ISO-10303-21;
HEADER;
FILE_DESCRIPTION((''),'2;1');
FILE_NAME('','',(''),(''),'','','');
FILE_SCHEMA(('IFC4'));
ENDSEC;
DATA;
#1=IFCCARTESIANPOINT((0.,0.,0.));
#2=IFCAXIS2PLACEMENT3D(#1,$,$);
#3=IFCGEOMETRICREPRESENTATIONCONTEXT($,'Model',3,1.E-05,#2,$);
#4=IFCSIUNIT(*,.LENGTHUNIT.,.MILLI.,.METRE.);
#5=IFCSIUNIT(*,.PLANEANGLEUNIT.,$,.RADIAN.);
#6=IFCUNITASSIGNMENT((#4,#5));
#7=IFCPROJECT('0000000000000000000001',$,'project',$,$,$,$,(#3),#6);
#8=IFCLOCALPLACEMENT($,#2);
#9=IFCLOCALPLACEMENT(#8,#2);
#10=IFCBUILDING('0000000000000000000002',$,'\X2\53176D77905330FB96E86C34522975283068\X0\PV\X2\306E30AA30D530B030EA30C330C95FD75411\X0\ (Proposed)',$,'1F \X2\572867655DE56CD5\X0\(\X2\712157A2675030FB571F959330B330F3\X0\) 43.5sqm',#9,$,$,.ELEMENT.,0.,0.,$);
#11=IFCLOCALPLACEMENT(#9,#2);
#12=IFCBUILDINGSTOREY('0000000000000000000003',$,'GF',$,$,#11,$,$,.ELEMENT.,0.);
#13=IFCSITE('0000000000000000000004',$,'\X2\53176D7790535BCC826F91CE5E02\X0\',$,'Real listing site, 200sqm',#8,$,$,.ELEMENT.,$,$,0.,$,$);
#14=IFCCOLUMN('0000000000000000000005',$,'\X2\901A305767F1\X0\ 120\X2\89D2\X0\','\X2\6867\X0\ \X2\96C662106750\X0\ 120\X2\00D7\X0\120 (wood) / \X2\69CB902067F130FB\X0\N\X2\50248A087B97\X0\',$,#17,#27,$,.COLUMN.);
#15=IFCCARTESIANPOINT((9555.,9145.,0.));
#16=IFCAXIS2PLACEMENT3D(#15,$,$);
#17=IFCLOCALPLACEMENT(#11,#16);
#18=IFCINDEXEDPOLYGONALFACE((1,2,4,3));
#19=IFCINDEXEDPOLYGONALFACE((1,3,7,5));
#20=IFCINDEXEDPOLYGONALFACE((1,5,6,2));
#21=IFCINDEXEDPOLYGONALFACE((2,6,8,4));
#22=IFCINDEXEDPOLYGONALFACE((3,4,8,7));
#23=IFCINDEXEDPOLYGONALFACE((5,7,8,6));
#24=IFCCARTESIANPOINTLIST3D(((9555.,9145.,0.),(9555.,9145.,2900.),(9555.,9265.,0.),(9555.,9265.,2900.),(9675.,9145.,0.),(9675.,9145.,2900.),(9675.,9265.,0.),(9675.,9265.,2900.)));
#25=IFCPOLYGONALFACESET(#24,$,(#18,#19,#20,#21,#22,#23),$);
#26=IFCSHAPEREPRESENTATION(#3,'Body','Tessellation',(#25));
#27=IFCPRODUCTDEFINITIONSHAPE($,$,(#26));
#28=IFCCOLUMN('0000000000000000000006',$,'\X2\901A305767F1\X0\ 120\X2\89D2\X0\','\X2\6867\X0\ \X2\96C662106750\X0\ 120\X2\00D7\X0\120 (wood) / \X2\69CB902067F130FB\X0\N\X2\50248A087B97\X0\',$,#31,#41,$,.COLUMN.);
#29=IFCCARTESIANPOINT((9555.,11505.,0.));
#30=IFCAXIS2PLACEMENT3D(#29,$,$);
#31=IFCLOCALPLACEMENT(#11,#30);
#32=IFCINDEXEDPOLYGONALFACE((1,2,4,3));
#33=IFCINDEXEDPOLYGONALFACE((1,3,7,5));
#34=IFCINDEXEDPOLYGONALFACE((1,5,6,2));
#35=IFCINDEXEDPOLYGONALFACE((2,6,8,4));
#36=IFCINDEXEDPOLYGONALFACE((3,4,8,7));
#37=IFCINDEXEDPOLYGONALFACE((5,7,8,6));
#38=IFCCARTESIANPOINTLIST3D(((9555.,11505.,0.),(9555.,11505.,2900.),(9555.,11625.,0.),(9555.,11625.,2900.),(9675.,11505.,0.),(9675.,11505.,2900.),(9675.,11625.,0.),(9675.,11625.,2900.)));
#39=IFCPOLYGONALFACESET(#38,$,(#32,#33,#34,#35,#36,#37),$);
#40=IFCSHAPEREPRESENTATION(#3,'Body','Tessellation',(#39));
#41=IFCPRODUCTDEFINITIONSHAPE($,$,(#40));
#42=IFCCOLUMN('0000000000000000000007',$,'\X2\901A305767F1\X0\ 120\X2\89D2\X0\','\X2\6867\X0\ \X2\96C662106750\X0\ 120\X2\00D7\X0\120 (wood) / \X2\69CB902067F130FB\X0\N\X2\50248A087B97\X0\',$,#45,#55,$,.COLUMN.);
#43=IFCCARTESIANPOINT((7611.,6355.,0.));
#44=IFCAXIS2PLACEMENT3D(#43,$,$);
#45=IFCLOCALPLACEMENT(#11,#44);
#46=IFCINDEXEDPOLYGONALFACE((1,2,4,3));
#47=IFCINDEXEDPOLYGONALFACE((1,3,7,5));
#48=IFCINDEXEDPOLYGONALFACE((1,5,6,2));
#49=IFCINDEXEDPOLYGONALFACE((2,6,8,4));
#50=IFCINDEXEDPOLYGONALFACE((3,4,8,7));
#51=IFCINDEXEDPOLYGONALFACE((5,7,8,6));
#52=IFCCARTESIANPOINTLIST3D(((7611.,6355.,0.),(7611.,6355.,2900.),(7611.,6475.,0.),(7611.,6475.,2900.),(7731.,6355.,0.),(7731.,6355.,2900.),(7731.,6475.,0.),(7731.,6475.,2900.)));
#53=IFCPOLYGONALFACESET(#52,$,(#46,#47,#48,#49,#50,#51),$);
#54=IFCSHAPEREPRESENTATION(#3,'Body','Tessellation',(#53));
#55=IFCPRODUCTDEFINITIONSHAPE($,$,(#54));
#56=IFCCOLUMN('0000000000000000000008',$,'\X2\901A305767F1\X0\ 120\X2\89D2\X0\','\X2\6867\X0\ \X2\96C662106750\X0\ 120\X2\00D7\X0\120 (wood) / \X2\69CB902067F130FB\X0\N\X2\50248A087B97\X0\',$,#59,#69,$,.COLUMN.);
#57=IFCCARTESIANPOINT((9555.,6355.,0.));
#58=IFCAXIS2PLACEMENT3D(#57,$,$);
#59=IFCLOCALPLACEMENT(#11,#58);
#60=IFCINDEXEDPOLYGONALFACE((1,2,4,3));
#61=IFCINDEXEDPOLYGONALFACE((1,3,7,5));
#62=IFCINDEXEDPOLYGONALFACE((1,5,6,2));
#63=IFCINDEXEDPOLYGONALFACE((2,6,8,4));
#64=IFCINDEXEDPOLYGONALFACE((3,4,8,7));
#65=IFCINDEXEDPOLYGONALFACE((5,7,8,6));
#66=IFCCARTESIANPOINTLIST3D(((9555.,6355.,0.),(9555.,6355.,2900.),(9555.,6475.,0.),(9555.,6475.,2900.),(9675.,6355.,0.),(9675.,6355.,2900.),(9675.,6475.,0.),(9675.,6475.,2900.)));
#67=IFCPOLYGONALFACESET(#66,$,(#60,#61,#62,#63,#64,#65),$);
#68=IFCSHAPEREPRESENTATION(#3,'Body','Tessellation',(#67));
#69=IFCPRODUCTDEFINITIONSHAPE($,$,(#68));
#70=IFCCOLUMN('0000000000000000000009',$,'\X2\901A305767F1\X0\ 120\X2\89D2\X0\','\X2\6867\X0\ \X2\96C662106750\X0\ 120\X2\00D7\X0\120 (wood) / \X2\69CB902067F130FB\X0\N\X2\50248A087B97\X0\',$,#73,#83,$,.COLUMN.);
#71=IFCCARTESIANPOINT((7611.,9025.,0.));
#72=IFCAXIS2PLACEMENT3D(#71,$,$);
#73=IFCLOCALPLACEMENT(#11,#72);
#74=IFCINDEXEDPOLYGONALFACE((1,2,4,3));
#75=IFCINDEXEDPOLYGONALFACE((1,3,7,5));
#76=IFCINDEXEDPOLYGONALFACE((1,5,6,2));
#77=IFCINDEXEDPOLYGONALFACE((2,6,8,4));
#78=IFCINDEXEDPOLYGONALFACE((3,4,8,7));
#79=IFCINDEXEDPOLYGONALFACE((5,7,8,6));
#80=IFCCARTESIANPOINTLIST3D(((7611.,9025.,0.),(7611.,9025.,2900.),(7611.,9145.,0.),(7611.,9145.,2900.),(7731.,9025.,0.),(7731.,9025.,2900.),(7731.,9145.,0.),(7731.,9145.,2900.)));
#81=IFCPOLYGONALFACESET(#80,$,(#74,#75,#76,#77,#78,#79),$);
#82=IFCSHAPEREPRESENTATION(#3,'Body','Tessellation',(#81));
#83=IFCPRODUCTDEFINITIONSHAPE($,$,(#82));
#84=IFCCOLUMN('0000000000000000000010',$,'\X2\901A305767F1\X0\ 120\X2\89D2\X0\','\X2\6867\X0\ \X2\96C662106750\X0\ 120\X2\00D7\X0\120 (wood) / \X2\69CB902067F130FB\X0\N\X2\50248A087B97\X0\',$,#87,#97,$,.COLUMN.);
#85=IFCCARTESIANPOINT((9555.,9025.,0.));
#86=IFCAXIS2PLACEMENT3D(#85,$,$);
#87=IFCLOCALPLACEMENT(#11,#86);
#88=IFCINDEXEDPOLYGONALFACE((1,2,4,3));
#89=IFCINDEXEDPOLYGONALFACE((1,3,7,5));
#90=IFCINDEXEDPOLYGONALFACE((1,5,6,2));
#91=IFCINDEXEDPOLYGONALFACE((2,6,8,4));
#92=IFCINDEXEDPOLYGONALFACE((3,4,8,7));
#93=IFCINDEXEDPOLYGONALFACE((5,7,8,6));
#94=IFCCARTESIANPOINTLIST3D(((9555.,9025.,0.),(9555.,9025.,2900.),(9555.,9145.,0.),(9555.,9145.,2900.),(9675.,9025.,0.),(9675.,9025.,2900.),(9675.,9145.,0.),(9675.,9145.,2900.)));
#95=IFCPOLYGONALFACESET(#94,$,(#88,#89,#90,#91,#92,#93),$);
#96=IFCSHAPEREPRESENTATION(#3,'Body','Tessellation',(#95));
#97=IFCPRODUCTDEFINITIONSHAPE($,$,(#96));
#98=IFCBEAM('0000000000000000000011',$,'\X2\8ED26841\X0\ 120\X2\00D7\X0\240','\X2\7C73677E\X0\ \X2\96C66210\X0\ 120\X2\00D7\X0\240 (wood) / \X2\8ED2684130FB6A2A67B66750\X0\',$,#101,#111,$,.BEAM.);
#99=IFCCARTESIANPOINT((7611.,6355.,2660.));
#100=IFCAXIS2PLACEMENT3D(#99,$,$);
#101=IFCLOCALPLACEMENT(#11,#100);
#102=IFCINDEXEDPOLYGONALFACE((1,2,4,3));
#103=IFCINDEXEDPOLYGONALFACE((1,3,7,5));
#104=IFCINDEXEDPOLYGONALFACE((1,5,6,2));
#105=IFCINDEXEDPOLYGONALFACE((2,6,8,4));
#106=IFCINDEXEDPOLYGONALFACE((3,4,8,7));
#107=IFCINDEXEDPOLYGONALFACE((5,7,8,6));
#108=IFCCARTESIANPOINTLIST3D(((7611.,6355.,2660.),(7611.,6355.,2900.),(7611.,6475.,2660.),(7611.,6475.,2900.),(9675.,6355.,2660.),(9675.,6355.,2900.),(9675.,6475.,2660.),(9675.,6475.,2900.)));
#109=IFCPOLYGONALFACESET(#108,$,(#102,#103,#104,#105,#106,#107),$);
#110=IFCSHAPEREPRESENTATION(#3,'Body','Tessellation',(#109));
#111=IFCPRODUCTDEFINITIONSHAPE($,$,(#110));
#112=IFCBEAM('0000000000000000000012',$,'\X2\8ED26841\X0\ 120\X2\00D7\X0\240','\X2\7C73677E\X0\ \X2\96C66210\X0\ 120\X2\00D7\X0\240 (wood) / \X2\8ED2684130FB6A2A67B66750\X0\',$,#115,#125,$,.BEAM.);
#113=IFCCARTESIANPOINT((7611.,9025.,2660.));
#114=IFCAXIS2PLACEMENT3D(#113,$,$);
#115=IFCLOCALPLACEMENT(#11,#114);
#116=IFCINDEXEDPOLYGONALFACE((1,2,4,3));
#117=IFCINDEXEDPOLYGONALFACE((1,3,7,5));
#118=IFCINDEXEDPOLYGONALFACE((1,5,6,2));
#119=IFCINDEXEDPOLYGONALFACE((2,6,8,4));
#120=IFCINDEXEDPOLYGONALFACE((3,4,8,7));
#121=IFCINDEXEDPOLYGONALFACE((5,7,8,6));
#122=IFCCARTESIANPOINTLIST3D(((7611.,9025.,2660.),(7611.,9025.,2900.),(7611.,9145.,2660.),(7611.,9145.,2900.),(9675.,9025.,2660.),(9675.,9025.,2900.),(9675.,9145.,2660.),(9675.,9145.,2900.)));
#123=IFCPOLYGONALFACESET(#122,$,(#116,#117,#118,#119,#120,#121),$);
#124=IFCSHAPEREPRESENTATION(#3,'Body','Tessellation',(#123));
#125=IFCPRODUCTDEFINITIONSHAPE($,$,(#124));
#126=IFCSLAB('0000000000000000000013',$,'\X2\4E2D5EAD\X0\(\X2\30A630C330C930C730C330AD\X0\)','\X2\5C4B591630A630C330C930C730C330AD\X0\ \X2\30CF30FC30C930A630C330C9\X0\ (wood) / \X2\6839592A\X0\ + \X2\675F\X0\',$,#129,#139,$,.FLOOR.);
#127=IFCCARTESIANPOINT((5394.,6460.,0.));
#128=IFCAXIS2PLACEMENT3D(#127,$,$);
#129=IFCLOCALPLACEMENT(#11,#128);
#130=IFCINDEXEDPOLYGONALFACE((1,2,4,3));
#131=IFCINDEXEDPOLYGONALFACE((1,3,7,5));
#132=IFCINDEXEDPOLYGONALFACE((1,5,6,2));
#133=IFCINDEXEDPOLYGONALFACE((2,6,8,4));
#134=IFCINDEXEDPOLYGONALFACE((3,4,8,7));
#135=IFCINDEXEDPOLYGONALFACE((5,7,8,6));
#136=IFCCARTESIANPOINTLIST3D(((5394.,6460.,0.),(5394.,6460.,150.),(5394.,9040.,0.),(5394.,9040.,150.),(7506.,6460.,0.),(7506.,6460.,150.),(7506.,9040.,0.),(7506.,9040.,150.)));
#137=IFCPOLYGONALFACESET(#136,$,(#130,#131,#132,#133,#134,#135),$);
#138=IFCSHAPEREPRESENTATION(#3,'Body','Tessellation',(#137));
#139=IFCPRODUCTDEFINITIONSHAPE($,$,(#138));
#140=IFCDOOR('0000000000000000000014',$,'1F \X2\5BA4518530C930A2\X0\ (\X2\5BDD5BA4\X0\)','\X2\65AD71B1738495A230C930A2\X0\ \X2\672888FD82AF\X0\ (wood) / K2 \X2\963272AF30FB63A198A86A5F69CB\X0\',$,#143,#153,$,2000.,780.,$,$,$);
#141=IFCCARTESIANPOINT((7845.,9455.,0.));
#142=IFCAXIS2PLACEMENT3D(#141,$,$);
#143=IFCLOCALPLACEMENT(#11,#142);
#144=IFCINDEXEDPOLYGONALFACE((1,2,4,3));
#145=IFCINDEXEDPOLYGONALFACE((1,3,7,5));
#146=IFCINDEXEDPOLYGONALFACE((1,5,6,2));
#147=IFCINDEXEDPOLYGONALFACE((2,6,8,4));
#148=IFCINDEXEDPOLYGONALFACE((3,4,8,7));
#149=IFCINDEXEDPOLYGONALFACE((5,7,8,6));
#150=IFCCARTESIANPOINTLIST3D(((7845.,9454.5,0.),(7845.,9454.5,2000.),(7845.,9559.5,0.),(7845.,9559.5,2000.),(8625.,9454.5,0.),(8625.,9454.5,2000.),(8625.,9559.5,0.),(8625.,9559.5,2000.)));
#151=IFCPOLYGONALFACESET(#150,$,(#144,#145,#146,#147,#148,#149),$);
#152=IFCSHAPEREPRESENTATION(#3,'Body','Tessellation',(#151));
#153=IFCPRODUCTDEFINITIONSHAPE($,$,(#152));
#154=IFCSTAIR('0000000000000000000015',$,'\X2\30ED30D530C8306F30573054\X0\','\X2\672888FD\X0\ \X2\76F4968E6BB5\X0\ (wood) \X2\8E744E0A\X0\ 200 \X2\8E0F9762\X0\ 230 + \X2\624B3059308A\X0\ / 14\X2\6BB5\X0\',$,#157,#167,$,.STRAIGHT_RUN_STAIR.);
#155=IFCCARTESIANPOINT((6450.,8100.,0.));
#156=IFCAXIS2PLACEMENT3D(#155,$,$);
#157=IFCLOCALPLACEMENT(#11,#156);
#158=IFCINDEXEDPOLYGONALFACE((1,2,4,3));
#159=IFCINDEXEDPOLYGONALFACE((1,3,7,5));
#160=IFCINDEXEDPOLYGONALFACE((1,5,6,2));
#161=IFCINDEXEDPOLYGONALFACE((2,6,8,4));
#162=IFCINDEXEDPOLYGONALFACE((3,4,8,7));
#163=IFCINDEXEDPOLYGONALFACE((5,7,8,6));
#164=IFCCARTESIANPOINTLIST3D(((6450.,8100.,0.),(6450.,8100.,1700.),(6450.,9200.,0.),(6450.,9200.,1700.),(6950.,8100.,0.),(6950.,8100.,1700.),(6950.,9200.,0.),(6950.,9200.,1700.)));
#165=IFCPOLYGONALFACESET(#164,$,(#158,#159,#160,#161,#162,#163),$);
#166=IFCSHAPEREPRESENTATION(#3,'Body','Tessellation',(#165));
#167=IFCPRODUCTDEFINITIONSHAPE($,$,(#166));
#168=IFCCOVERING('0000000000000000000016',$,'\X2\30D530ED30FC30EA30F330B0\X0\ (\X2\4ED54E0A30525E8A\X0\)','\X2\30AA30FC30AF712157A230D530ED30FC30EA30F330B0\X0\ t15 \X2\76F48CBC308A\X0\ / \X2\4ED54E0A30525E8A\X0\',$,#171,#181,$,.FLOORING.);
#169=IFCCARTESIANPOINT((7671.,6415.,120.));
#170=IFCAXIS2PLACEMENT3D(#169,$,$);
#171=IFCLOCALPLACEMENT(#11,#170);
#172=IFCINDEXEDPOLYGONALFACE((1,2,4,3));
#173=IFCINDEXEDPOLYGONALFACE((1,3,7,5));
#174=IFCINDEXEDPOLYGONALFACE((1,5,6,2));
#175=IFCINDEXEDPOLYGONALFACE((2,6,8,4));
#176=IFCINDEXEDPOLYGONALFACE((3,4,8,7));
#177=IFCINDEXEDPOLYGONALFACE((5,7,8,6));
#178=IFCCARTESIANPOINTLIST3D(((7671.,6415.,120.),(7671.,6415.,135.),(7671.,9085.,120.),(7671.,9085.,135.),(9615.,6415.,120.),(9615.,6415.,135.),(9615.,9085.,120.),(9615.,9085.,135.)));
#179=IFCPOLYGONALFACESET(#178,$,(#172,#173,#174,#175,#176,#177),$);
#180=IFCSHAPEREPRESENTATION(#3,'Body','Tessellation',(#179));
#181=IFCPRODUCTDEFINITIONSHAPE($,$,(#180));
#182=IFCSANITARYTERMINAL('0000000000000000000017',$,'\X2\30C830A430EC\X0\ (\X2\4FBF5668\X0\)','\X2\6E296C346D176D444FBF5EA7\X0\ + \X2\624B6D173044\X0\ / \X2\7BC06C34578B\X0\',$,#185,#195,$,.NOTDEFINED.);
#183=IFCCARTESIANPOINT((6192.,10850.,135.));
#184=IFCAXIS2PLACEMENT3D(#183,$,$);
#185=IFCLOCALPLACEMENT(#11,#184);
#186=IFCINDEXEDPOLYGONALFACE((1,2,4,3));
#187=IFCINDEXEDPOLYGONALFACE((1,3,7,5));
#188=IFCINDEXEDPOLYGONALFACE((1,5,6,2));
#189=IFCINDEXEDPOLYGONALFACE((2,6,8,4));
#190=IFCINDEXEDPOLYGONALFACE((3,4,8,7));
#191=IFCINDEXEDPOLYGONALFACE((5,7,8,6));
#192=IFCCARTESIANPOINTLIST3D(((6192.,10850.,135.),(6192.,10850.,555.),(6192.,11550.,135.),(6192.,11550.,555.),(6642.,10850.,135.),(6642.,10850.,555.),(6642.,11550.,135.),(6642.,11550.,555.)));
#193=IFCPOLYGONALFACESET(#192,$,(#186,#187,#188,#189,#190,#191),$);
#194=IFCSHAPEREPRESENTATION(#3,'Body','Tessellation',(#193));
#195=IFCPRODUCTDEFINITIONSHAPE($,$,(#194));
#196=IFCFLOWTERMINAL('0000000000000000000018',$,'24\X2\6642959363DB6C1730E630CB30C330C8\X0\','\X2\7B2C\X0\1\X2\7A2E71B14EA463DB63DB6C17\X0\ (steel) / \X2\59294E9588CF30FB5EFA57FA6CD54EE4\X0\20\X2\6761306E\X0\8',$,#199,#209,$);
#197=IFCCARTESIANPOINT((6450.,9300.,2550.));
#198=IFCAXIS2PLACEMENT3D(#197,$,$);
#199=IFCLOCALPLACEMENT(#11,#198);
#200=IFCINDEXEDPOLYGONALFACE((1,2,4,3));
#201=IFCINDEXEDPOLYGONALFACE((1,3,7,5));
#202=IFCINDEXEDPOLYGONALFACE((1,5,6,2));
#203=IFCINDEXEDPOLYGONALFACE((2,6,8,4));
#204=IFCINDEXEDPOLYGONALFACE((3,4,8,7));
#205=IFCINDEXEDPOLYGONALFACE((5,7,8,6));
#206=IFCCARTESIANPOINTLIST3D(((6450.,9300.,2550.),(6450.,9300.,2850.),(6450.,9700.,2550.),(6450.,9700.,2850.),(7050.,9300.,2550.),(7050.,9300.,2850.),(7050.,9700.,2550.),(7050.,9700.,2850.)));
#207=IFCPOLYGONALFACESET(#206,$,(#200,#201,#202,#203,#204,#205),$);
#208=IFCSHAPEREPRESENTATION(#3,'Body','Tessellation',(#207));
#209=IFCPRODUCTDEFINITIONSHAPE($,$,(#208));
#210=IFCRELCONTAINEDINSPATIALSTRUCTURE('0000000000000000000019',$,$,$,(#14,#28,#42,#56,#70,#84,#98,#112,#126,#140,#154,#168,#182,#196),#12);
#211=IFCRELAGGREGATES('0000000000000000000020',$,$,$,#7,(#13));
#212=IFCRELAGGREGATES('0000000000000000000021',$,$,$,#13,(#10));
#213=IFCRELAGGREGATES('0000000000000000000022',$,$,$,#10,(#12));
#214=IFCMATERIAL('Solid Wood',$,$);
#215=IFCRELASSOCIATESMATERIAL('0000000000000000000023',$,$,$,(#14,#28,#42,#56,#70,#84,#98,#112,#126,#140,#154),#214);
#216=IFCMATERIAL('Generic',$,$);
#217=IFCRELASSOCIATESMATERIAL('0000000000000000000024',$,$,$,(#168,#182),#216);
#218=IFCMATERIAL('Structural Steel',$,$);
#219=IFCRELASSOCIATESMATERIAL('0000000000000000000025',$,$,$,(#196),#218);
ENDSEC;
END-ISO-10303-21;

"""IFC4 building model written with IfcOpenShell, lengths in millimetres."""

from ifc_helpers import new_model, si_unit, frame, frame_2d, origin, place, context, project, spatial, rectangle, extrude, material, element, save


model = new_model("IFC4")

# Units and contexts
model_context = context("Model", 3, precision=1e-05, world=origin())
ifc_project = project(units=[si_unit("LENGTHUNIT", "METRE", prefix="MILLI"), si_unit("PLANEANGLEUNIT", "RADIAN")], contexts=[model_context])

# Site, building, storey
site_placement = place(None, origin())
site = spatial("IfcSite", under=ifc_project, at=site_placement, Name="北海道富良野市", ObjectType="Real listing site, 200sqm", CompositionType="ELEMENT", RefElevation=0.0)
building_placement = place(site_placement, origin())
building = spatial("IfcBuilding", under=site, at=building_placement, Name="北海道・雨水利用とPVのオフグリッド志向 (Proposed)", ObjectType="1F 在来工法(無垢材・土間コン) 43.5sqm", CompositionType="ELEMENT", ElevationOfRefHeight=0.0, ElevationOfTerrain=0.0)
storey_placement = place(building_placement, origin())
storey = spatial("IfcBuildingStorey", under=building, at=storey_placement, Name="GF", CompositionType="ELEMENT", Elevation=0.0)

# Columns
ifc_material_1 = material(Name="Solid Wood")
column_1_placement = place(storey_placement, frame((9555.0, 9145.0, 0.0)))
element("IfcColumn", 1, at=column_1_placement, inside=storey, material=ifc_material_1, Name="通し柱 120角", Description="桧 集成材 120×120 (wood) / 構造柱・N値計算", PredefinedType="COLUMN", context=model_context, shape_type="SweptSolid", body=[
    extrude(rectangle(XDim=120.0, YDim=120.0, at=frame_2d((60.0, 60.0))), frame((9555.0, 9145.0, 0.0)), (0.0, 0.0, 1.0), 2900.0),
])
column_2_placement = place(storey_placement, frame((9555.0, 11505.0, 0.0)))
element("IfcColumn", 2, at=column_2_placement, inside=storey, material=ifc_material_1, Name="通し柱 120角", Description="桧 集成材 120×120 (wood) / 構造柱・N値計算", PredefinedType="COLUMN", context=model_context, shape_type="SweptSolid", body=[
    extrude(rectangle(XDim=120.0, YDim=120.0, at=frame_2d((60.0, 60.0))), frame((9555.0, 11505.0, 0.0)), (0.0, 0.0, 1.0), 2900.0),
])
column_3_placement = place(storey_placement, frame((7611.0, 6355.0, 0.0)))
element("IfcColumn", 3, at=column_3_placement, inside=storey, material=ifc_material_1, Name="通し柱 120角", Description="桧 集成材 120×120 (wood) / 構造柱・N値計算", PredefinedType="COLUMN", context=model_context, shape_type="SweptSolid", body=[
    extrude(rectangle(XDim=120.0, YDim=120.0, at=frame_2d((60.0, 60.0))), frame((7611.0, 6355.0, 0.0)), (0.0, 0.0, 1.0), 2900.0),
])
column_4_placement = place(storey_placement, frame((9555.0, 6355.0, 0.0)))
element("IfcColumn", 4, at=column_4_placement, inside=storey, material=ifc_material_1, Name="通し柱 120角", Description="桧 集成材 120×120 (wood) / 構造柱・N値計算", PredefinedType="COLUMN", context=model_context, shape_type="SweptSolid", body=[
    extrude(rectangle(XDim=120.0, YDim=120.0, at=frame_2d((60.0, 60.0))), frame((9555.0, 6355.0, 0.0)), (0.0, 0.0, 1.0), 2900.0),
])
column_5_placement = place(storey_placement, frame((7611.0, 9025.0, 0.0)))
element("IfcColumn", 5, at=column_5_placement, inside=storey, material=ifc_material_1, Name="通し柱 120角", Description="桧 集成材 120×120 (wood) / 構造柱・N値計算", PredefinedType="COLUMN", context=model_context, shape_type="SweptSolid", body=[
    extrude(rectangle(XDim=120.0, YDim=120.0, at=frame_2d((60.0, 60.0))), frame((7611.0, 9025.0, 0.0)), (0.0, 0.0, 1.0), 2900.0),
])
column_6_placement = place(storey_placement, frame((9555.0, 9025.0, 0.0)))
element("IfcColumn", 6, at=column_6_placement, inside=storey, material=ifc_material_1, Name="通し柱 120角", Description="桧 集成材 120×120 (wood) / 構造柱・N値計算", PredefinedType="COLUMN", context=model_context, shape_type="SweptSolid", body=[
    extrude(rectangle(XDim=120.0, YDim=120.0, at=frame_2d((60.0, 60.0))), frame((9555.0, 9025.0, 0.0)), (0.0, 0.0, 1.0), 2900.0),
])

# Beams
beam_1_placement = place(storey_placement, frame((7611.0, 6355.0, 2660.0)))
element("IfcBeam", 7, at=beam_1_placement, inside=storey, material=ifc_material_1, Name="軒桁 120×240", Description="米松 集成 120×240 (wood) / 軒桁・横架材", PredefinedType="BEAM", context=model_context, shape_type="SweptSolid", body=[
    extrude(rectangle(XDim=2064.0, YDim=120.0, at=frame_2d((1032.0, 60.0))), frame((7611.0, 6355.0, 2660.0)), (0.0, 0.0, 1.0), 240.0),
])
beam_2_placement = place(storey_placement, frame((7611.0, 9025.0, 2660.0)))
element("IfcBeam", 8, at=beam_2_placement, inside=storey, material=ifc_material_1, Name="軒桁 120×240", Description="米松 集成 120×240 (wood) / 軒桁・横架材", PredefinedType="BEAM", context=model_context, shape_type="SweptSolid", body=[
    extrude(rectangle(XDim=2064.0, YDim=120.0, at=frame_2d((1032.0, 60.0))), frame((7611.0, 9025.0, 2660.0)), (0.0, 0.0, 1.0), 240.0),
])

# Slab
slab_placement = place(storey_placement, frame((5394.0, 6460.0, 0.0)))
element("IfcSlab", 9, at=slab_placement, inside=storey, material=ifc_material_1, Name="中庭(ウッドデッキ)", Description="屋外ウッドデッキ ハードウッド (wood) / 根太 + 束", PredefinedType="FLOOR", context=model_context, shape_type="SweptSolid", body=[
    extrude(rectangle(XDim=2112.0, YDim=2580.0, at=frame_2d((1056.0, 1290.0))), frame((5394.0, 6460.0, 0.0)), (0.0, 0.0, 1.0), 150.0),
])

# Door
door_placement = place(storey_placement, frame((7845.0, 9455.0, 0.0)))
element("IfcDoor", 10, at=door_placement, inside=storey, material=ifc_material_1, Name="1F 室内ドア (寝室)", Description="断熱玄関ドア 木製芯 (wood) / K2 防犯・採風機構", OverallHeight=2000.0, OverallWidth=780.0, context=model_context, shape_type="SweptSolid", body=[
    extrude(rectangle(XDim=780.0, YDim=105.0, at=frame_2d((390.0, 52.0))), frame((7845.0, 9455.0, 0.0)), (0.0, 0.0, 1.0), 2000.0),
])

# Stair
stair_placement = place(storey_placement, frame((6450.0, 8100.0, 0.0)))
element("IfcStair", 11, at=stair_placement, inside=storey, material=ifc_material_1, Name="ロフトはしご", Description="木製 直階段 (wood) 蹴上 200 踏面 230 + 手すり / 14段", PredefinedType="STRAIGHT_RUN_STAIR", context=model_context, shape_type="SweptSolid", body=[
    extrude(rectangle(XDim=500.0, YDim=1100.0, at=frame_2d((250.0, 550.0))), frame((6450.0, 8100.0, 0.0)), (0.0, 0.0, 1.0), 1700.0),
])

# Covering
ifc_material_2 = material(Name="Generic")
covering_placement = place(storey_placement, frame((7671.0, 6415.0, 120.0)))
element("IfcCovering", 12, at=covering_placement, inside=storey, material=ifc_material_2, Name="フローリング (仕上げ床)", Description="オーク無垢フローリング t15 直貼り / 仕上げ床", PredefinedType="FLOORING", context=model_context, shape_type="SweptSolid", body=[
    extrude(rectangle(XDim=1944.0, YDim=2670.0, at=frame_2d((972.0, 1335.0))), frame((7671.0, 6415.0, 120.0)), (0.0, 0.0, 1.0), 15.0),
])

# Sanitary terminal
sanitary_terminal_placement = place(storey_placement, frame((6192.0, 10850.0, 135.0)))
element("IfcSanitaryTerminal", 13, at=sanitary_terminal_placement, inside=storey, material=ifc_material_2, Name="トイレ (便器)", Description="温水洗浄便座 + 手洗い / 節水型", PredefinedType="NOTDEFINED", context=model_context, shape_type="SweptSolid", body=[
    extrude(rectangle(XDim=450.0, YDim=700.0, at=frame_2d((225.0, 350.0))), frame((6192.0, 10850.0, 135.0)), (0.0, 0.0, 1.0), 420.0),
])

# Flow terminal
ifc_material_3 = material(Name="Structural Steel")
flow_terminal_placement = place(storey_placement, frame((6450.0, 9300.0, 2550.0)))
element("IfcFlowTerminal", 14, at=flow_terminal_placement, inside=storey, material=ifc_material_3, Name="24時間換気ユニット", Description="第1種熱交換換気 (steel) / 天井裏・建基法令20条の8", context=model_context, shape_type="SweptSolid", body=[
    extrude(rectangle(XDim=600.0, YDim=400.0, at=frame_2d((300.0, 200.0))), frame((6450.0, 9300.0, 2550.0)), (0.0, 0.0, 1.0), 300.0),
])

save(model, "model.ifc")
